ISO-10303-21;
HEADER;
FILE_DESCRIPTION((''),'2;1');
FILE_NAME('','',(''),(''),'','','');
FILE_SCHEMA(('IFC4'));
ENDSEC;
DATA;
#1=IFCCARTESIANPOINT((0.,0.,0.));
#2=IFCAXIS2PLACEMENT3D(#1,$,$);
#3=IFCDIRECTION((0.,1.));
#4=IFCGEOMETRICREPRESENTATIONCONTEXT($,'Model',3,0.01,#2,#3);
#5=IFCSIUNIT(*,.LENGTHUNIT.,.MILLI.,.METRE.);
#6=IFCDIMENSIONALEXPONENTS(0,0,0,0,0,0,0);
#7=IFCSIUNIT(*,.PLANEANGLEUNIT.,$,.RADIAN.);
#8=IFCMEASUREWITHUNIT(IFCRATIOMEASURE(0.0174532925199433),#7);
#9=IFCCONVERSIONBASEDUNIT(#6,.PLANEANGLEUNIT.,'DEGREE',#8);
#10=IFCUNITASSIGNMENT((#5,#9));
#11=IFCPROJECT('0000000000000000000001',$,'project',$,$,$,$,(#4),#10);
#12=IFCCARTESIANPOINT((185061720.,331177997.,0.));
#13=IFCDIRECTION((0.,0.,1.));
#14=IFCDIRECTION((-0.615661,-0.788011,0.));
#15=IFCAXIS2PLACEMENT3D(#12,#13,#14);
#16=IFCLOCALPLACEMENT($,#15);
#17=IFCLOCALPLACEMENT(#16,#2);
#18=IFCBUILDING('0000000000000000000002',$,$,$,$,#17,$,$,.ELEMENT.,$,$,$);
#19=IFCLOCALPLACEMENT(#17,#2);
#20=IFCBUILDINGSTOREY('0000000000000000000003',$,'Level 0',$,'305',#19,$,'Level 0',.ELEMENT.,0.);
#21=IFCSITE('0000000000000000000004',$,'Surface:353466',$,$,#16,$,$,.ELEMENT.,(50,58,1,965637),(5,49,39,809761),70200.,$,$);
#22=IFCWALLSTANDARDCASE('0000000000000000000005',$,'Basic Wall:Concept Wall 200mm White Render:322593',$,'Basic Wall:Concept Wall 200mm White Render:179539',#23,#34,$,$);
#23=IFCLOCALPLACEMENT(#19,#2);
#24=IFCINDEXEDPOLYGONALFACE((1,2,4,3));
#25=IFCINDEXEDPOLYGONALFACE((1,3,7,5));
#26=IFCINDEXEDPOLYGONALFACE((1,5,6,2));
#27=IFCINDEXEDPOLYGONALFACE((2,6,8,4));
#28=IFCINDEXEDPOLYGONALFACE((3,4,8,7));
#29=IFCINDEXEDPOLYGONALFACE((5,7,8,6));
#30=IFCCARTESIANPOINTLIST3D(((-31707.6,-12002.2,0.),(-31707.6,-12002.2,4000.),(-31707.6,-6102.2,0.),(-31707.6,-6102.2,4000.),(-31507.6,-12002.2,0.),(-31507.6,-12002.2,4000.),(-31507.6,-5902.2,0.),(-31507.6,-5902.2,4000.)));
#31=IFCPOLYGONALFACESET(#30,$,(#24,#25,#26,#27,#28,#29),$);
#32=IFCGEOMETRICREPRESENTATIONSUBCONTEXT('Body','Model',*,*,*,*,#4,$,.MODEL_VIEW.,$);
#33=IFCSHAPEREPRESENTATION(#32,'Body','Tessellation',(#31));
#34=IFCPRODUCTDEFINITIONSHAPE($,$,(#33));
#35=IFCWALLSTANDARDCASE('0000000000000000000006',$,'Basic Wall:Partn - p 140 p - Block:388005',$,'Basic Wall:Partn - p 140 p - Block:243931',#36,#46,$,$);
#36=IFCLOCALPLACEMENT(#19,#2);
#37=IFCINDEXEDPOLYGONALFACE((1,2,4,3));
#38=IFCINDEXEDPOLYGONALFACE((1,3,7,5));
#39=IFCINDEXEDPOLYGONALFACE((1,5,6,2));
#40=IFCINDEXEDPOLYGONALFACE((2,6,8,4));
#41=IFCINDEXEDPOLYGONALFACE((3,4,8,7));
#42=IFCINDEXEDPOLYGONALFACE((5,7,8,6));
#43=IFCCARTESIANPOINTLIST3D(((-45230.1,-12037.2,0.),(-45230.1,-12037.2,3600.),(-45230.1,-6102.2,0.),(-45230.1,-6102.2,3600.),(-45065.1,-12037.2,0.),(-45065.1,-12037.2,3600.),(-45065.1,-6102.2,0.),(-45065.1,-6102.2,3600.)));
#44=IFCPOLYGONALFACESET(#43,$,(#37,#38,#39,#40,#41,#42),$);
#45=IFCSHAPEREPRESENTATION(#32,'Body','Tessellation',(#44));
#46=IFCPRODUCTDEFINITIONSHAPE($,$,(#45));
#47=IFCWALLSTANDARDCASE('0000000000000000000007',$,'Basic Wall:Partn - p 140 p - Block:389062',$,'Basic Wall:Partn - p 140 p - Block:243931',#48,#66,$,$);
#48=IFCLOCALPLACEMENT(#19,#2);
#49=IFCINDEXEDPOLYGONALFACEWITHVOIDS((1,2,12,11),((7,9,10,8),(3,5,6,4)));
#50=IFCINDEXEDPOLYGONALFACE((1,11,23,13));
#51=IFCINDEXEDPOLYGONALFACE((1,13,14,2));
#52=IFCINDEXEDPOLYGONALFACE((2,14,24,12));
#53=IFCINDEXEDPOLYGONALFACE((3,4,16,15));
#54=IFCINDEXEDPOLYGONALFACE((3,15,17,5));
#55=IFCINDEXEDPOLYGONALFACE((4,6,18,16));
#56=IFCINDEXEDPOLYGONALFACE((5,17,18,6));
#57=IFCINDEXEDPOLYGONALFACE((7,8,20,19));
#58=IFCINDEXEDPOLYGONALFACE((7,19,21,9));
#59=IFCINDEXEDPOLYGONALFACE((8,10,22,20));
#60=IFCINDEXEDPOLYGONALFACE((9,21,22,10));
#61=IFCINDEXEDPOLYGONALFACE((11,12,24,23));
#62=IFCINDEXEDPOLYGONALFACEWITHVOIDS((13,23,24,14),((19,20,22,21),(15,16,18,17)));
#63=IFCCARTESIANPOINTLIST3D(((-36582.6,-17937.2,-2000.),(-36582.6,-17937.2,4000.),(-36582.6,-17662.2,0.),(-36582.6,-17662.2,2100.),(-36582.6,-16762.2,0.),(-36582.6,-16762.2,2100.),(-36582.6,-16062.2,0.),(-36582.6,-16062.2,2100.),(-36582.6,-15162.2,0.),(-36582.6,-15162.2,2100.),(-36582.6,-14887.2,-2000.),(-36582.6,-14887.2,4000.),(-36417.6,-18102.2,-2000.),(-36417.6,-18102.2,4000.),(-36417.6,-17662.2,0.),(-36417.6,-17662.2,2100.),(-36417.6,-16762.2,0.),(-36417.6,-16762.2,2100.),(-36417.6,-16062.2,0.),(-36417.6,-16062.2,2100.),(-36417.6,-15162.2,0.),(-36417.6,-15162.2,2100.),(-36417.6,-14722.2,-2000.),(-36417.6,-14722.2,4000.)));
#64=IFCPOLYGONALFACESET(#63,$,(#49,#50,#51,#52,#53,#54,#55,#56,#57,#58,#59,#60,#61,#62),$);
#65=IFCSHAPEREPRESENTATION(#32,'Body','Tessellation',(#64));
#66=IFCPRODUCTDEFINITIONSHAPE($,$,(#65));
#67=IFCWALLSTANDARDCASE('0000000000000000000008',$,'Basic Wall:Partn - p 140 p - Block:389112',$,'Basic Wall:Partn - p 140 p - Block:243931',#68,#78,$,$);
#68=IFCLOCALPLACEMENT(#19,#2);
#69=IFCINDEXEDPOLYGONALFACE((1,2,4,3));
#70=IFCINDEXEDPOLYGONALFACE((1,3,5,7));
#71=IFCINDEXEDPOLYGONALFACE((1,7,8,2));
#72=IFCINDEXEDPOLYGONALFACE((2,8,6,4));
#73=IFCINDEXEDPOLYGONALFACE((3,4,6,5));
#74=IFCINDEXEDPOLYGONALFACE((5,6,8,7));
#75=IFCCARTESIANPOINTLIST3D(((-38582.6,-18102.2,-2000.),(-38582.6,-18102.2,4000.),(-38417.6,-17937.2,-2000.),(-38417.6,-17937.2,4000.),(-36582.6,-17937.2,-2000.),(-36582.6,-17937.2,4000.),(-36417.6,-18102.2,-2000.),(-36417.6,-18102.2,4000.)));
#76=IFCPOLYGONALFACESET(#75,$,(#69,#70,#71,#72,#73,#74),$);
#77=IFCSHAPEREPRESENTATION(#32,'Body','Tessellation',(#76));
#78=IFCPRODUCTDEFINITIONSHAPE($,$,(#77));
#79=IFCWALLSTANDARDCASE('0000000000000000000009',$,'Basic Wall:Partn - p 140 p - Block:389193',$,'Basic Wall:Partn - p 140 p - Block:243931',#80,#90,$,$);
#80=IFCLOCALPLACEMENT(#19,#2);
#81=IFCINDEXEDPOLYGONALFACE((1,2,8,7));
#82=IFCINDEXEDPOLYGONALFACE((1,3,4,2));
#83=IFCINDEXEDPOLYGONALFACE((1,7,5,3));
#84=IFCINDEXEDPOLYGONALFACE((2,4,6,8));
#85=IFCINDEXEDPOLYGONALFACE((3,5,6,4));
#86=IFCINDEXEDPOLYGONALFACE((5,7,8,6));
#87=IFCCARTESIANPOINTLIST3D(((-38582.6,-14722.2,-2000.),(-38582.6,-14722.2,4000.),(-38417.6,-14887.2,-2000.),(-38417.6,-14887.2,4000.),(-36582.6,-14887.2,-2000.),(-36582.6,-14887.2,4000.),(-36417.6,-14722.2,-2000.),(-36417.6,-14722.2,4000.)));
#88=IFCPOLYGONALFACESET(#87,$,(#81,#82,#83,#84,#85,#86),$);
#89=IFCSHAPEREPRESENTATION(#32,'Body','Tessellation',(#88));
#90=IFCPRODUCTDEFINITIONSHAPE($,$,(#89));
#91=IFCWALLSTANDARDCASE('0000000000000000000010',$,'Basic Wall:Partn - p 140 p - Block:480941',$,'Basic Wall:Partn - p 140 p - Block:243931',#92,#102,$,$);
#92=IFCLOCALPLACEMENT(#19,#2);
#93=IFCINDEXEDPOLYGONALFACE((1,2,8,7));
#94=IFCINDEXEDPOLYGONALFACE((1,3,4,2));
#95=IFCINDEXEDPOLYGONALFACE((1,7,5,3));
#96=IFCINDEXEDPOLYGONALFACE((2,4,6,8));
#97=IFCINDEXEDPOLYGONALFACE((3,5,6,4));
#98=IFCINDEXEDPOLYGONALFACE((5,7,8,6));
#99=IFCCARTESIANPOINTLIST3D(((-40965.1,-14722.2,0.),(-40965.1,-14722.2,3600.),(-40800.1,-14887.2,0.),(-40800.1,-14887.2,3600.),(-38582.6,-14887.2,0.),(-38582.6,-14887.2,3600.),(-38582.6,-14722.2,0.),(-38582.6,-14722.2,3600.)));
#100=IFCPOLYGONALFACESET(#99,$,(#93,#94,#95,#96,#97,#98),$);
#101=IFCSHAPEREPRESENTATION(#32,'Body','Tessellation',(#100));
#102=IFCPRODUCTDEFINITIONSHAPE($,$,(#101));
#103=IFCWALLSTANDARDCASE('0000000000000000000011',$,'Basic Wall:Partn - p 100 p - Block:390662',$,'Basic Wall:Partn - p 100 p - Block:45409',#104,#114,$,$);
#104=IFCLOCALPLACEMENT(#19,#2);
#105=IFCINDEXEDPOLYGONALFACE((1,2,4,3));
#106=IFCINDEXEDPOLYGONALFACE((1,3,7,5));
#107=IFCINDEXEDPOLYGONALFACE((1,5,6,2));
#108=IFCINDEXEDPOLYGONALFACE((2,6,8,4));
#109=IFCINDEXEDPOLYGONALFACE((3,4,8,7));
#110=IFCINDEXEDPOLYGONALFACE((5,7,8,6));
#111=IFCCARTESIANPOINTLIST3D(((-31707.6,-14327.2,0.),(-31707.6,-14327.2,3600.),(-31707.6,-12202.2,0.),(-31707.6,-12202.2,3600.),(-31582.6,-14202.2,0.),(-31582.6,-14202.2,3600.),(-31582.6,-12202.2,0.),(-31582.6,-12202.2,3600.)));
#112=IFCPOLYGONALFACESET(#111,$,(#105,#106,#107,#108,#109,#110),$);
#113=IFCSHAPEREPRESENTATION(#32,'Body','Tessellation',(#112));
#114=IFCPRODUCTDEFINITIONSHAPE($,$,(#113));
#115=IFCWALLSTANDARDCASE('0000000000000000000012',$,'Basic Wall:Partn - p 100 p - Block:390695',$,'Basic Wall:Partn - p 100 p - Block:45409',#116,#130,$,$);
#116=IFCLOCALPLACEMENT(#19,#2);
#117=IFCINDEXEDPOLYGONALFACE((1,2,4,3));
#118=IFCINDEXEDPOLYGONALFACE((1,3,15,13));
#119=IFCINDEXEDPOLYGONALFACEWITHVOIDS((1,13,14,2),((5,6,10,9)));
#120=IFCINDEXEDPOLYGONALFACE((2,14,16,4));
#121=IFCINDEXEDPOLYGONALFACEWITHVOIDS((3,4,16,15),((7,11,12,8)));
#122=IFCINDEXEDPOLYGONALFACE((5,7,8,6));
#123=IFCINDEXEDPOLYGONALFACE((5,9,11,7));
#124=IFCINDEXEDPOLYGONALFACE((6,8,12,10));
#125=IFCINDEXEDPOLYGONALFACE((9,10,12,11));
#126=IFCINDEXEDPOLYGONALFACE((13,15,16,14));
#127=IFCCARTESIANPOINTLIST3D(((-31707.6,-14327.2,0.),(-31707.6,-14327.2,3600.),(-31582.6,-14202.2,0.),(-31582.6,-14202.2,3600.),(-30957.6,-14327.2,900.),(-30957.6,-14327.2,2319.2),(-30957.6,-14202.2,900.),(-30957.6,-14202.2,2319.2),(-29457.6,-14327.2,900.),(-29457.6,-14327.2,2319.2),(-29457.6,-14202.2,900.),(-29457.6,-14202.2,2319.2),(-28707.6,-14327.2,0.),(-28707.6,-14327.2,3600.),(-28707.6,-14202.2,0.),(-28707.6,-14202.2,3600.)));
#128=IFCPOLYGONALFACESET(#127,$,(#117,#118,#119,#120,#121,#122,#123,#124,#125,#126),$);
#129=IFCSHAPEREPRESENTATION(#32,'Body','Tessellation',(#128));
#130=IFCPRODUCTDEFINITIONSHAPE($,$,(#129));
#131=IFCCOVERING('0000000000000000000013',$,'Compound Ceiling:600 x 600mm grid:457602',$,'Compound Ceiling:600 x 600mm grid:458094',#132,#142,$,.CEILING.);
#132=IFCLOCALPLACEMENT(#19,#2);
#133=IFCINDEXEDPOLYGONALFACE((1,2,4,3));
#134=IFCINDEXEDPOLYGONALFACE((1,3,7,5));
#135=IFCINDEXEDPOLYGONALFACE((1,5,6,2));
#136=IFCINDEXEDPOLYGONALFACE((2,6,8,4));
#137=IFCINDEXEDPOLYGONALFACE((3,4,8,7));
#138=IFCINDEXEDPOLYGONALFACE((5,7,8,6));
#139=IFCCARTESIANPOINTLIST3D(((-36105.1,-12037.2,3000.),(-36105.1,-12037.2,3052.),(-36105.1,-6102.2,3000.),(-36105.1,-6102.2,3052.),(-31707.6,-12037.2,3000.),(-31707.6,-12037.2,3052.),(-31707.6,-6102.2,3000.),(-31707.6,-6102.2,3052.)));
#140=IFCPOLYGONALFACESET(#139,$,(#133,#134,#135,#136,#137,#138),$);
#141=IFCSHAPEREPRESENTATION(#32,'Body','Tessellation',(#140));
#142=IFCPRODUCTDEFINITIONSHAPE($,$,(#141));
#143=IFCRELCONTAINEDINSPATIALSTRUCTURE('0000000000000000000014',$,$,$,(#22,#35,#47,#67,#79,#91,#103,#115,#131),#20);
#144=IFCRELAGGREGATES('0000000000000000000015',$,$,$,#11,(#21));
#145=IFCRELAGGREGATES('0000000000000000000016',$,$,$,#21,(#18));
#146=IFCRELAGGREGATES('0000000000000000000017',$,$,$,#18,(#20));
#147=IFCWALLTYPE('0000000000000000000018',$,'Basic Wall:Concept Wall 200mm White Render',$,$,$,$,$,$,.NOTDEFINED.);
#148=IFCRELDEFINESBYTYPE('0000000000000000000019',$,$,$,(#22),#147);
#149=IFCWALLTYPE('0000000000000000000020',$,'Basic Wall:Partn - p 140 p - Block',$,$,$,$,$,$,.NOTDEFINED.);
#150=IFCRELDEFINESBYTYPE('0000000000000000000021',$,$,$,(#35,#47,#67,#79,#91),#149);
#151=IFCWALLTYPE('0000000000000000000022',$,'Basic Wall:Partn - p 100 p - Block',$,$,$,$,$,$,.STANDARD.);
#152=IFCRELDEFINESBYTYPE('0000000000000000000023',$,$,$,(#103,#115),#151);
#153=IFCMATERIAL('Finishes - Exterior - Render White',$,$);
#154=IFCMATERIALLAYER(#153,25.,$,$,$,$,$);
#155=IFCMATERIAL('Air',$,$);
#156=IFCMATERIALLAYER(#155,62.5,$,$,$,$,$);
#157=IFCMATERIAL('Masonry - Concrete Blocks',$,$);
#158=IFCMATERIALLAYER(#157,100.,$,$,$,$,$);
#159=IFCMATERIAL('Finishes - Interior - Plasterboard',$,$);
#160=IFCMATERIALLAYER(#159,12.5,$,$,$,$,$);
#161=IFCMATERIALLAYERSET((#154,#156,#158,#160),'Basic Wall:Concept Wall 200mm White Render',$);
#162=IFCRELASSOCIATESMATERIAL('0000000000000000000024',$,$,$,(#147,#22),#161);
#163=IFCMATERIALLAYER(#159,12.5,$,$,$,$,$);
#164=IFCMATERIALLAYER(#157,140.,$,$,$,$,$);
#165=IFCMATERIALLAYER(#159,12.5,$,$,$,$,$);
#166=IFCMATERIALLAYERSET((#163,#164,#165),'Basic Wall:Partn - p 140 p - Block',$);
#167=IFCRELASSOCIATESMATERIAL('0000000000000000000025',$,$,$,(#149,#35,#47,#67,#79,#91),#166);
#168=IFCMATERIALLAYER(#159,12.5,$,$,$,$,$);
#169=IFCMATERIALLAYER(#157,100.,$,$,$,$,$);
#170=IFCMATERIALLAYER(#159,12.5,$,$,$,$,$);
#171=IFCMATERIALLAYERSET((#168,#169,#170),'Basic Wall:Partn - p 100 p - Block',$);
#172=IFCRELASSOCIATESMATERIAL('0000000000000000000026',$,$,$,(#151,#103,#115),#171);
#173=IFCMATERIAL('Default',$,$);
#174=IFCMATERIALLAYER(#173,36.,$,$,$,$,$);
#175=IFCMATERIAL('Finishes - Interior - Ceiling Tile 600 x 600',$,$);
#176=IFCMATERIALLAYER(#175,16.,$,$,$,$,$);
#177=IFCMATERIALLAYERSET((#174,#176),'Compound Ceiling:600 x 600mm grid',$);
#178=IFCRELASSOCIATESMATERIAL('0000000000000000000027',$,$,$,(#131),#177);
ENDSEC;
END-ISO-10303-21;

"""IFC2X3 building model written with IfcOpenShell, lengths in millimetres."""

from ifc_helpers import new_model, entity, si_unit, converted_unit, direction, frame, frame_2d, origin, place, context, subcontext, project, spatial, polyline, rectangle, outline, extrude, clip, halfspace, bounded_halfspace, material, layer, layer_set, layer_usage, type_object, element, save


model = new_model("IFC2X3")

# Units and contexts
model_context = context("Model", 3, precision=0.01, world=origin(), true_north=direction((0.0, 1.0)))
body_context = subcontext(model_context, "Body", "Model", "MODEL_VIEW")
ifc_project = project(units=[si_unit("LENGTHUNIT", "METRE", prefix="MILLI"), converted_unit("PLANEANGLEUNIT", "DEGREE", entity("IfcRatioMeasure", 0.0174532925199433), si_unit("PLANEANGLEUNIT", "RADIAN"), dimensions=[0, 0, 0, 0, 0, 0, 0])], contexts=[model_context])

# Site, building, storey
site_placement = place(None, frame((185061720.0, 331177997.0, 0.0), z_axis=(0.0, 0.0, 1.0), x_axis=(-0.615661, -0.788011, 0.0)))
site = spatial("IfcSite", under=ifc_project, at=site_placement, Name="Surface:353466", CompositionType="ELEMENT", RefLatitude=(50, 58, 1, 965637), RefLongitude=(5, 49, 39, 809761), RefElevation=70200.0)
building_placement = place(site_placement, origin())
building = spatial("IfcBuilding", under=site, at=building_placement, CompositionType="ELEMENT")
storey_placement = place(building_placement, origin())
storey = spatial("IfcBuildingStorey", under=building, at=storey_placement, Name="Level 0", ObjectType="305", LongName="Level 0", CompositionType="ELEMENT", Elevation=0.0)

# Walls
ifc_material_1 = material(Name="Finishes - Exterior - Render White")
ifc_layer_1 = layer(ifc_material_1, 25.0)
ifc_material_2 = material(Name="Air")
ifc_layer_2 = layer(ifc_material_2, 62.5)
ifc_material_3 = material(Name="Masonry - Concrete Blocks")
ifc_layer_3 = layer(ifc_material_3, 100.0)
ifc_material_4 = material(Name="Finishes - Interior - Plasterboard")
ifc_layer_4 = layer(ifc_material_4, 12.5)
ifc_layer_set_1 = layer_set([ifc_layer_1, ifc_layer_2, ifc_layer_3, ifc_layer_4], Name="Basic Wall:Concept Wall 200mm White Render")
ifc_layer_usage_1 = layer_usage(ifc_layer_set_1, "AXIS2", "POSITIVE", -100.0)
wall_type_1 = type_object("IfcWallType", Name="Basic Wall:Concept Wall 200mm White Render", PredefinedType="NOTDEFINED", material=ifc_layer_set_1)
wall_1_placement = place(storey_placement, frame((-31607.6, -12002.2, 0.0), z_axis=(0.0, 0.0, 1.0), x_axis=(0.0, 1.0, 0.0)))
element("IfcWallStandardCase", 1, at=wall_1_placement, inside=storey, type_object=wall_type_1, material=ifc_layer_usage_1, Name="Basic Wall:Concept Wall 200mm White Render:322593", ObjectType="Basic Wall:Concept Wall 200mm White Render:179539", context=body_context, shape_type="Clipping", body=[
    clip(extrude(outline(polyline([(6100.0, -100.0), (5900.0, 100.0), (0.0, 100.0), (0.0, -100.0), (6100.0, -100.0)])), origin(), (0.0, 0.0, 1.0), 4000.0), halfspace(origin(), True)),
])
ifc_layer_5 = layer(ifc_material_4, 12.5)
ifc_layer_6 = layer(ifc_material_3, 140.0)
ifc_layer_7 = layer(ifc_material_4, 12.5)
ifc_layer_set_2 = layer_set([ifc_layer_5, ifc_layer_6, ifc_layer_7], Name="Basic Wall:Partn - p 140 p - Block")
ifc_layer_usage_2 = layer_usage(ifc_layer_set_2, "AXIS2", "NEGATIVE", 82.5)
wall_type_2 = type_object("IfcWallType", Name="Basic Wall:Partn - p 140 p - Block", PredefinedType="NOTDEFINED", material=ifc_layer_set_2)
wall_2_placement = place(storey_placement, frame((-45147.6, -6102.2, 0.0), z_axis=(0.0, 0.0, 1.0), x_axis=(0.0, -1.0, 0.0)))
element("IfcWallStandardCase", 2, at=wall_2_placement, inside=storey, type_object=wall_type_2, material=ifc_layer_usage_2, Name="Basic Wall:Partn - p 140 p - Block:388005", ObjectType="Basic Wall:Partn - p 140 p - Block:243931", context=body_context, shape_type="Clipping", body=[
    clip(extrude(rectangle(XDim=5935.0, YDim=165.0, at=frame_2d((2967.5, 0.0), x_axis=(-1.0, 0.0))), origin(), (0.0, 0.0, 1.0), 3600.0), bounded_halfspace(frame((0.0, -82.5, 3600.0), z_axis=(0.0, 0.0, -1.0), x_axis=(0.0, 1.0, 0.0)), True, frame((0.0, -82.5, 3600.0)), polyline([(0.0, 0.0), (5935.0, 0.0), (5935.0, 165.0), (0.0, 165.0), (0.0, 0.0)]))),
])

# Wall, openings
ifc_layer_usage_3 = layer_usage(ifc_layer_set_2, "AXIS2", "NEGATIVE", 82.5)
wall_3_placement = place(storey_placement, frame((-36500.1, -14722.2, -2000.0), z_axis=(0.0, 0.0, 1.0), x_axis=(0.0, -1.0, 0.0)))
wall_3 = element("IfcWallStandardCase", 3, at=wall_3_placement, inside=storey, type_object=wall_type_2, material=ifc_layer_usage_3, Name="Basic Wall:Partn - p 140 p - Block:389062", ObjectType="Basic Wall:Partn - p 140 p - Block:243931", context=body_context, shape_type="Clipping", body=[
    clip(extrude(outline(polyline([(3215.0, -82.5), (3380.0, 82.5), (0.0, 82.5), (165.0, -82.5), (3215.0, -82.5)])), origin(), (0.0, 0.0, 1.0), 6000.0), halfspace(frame((0.0, 0.0, -2000.0)), True)),
])
opening_1_placement = place(wall_3_placement, frame((1340.0, -1606.5, 2000.0)))
element("IfcOpeningElement", 4, at=opening_1_placement, cuts=wall_3, ObjectType="Opening", context=body_context, shape_type="SweptSolid", body=[
    extrude(rectangle(XDim=2100.0, YDim=900.0, at=frame_2d((0.0, 0.0), x_axis=(0.0, 1.0))), frame((-450.0, 0.0, 1050.0), z_axis=(0.0, 1.0, 0.0), x_axis=(-1.0, 0.0, 0.0)), (0.0, 0.0, 1.0), 3048.0),
])
opening_2_placement = place(wall_3_placement, frame((2940.0, -1606.5, 2000.0)))
element("IfcOpeningElement", 5, at=opening_2_placement, cuts=wall_3, ObjectType="Opening", context=body_context, shape_type="SweptSolid", body=[
    extrude(rectangle(XDim=2100.0, YDim=900.0, at=frame_2d((0.0, 0.0), x_axis=(0.0, 1.0))), frame((-450.0, 0.0, 1050.0), z_axis=(0.0, 1.0, 0.0), x_axis=(-1.0, 0.0, 0.0)), (0.0, 0.0, 1.0), 3048.0),
])
opening_3_placement = place(wall_3_placement, frame((1340.0, -1606.5, 6000.0)))
element("IfcOpeningElement", 6, at=opening_3_placement, cuts=wall_3, ObjectType="Opening", context=body_context, shape_type="SweptSolid", body=[
    extrude(rectangle(XDim=2100.0, YDim=900.0, at=frame_2d((0.0, 0.0), x_axis=(0.0, 1.0))), frame((-450.0, 0.0, 1050.0), z_axis=(0.0, 1.0, 0.0), x_axis=(-1.0, 0.0, 0.0)), (0.0, 0.0, 1.0), 3048.0),
])
opening_4_placement = place(wall_3_placement, frame((2940.0, -1606.5, 6000.0)))
element("IfcOpeningElement", 7, at=opening_4_placement, cuts=wall_3, ObjectType="Opening", context=body_context, shape_type="SweptSolid", body=[
    extrude(rectangle(XDim=2100.0, YDim=900.0, at=frame_2d((0.0, 0.0), x_axis=(0.0, 1.0))), frame((-450.0, 0.0, 1050.0), z_axis=(0.0, 1.0, 0.0), x_axis=(-1.0, 0.0, 0.0)), (0.0, 0.0, 1.0), 3048.0),
])

# Walls
ifc_layer_usage_4 = layer_usage(ifc_layer_set_2, "AXIS2", "NEGATIVE", 82.5)
wall_4_placement = place(storey_placement, frame((-36417.6, -18019.7, -2000.0), z_axis=(0.0, 0.0, 1.0), x_axis=(-1.0, 0.0, 0.0)))
element("IfcWallStandardCase", 8, at=wall_4_placement, inside=storey, type_object=wall_type_2, material=ifc_layer_usage_4, Name="Basic Wall:Partn - p 140 p - Block:389112", ObjectType="Basic Wall:Partn - p 140 p - Block:243931", context=body_context, shape_type="Clipping", body=[
    clip(extrude(outline(polyline([(2000.0, -82.5), (2165.0, 82.5), (0.0, 82.5), (165.0, -82.5), (2000.0, -82.5)])), origin(), (0.0, 0.0, 1.0), 6000.0), halfspace(frame((0.0, 0.0, -2000.0)), True)),
])
ifc_layer_usage_5 = layer_usage(ifc_layer_set_2, "AXIS2", "NEGATIVE", 82.5)
wall_5_placement = place(storey_placement, frame((-38582.6, -14804.7, -2000.0)))
element("IfcWallStandardCase", 9, at=wall_5_placement, inside=storey, type_object=wall_type_2, material=ifc_layer_usage_5, Name="Basic Wall:Partn - p 140 p - Block:389193", ObjectType="Basic Wall:Partn - p 140 p - Block:243931", context=body_context, shape_type="Clipping", body=[
    clip(extrude(outline(polyline([(2000.0, -82.5), (2165.0, 82.5), (0.0, 82.5), (165.0, -82.5), (2000.0, -82.5)])), origin(), (0.0, 0.0, 1.0), 6000.0), halfspace(frame((0.0, 0.0, -2000.0)), True)),
])
ifc_layer_usage_6 = layer_usage(ifc_layer_set_2, "AXIS2", "NEGATIVE", 82.5)
wall_6_placement = place(storey_placement, frame((-38582.6, -14804.7, 0.0), z_axis=(0.0, 0.0, 1.0), x_axis=(-1.0, 0.0, 0.0)))
element("IfcWallStandardCase", 10, at=wall_6_placement, inside=storey, type_object=wall_type_2, material=ifc_layer_usage_6, Name="Basic Wall:Partn - p 140 p - Block:480941", ObjectType="Basic Wall:Partn - p 140 p - Block:243931", context=body_context, shape_type="Clipping", body=[
    clip(extrude(outline(polyline([(2382.5, -82.5), (2217.5, 82.5), (0.0, 82.5), (0.0, -82.5), (2382.5, -82.5)])), origin(), (0.0, 0.0, 1.0), 3600.0), bounded_halfspace(frame((0.0, -82.5, 3600.0), z_axis=(0.0, 0.0, -1.0), x_axis=(-1.0, 0.0, 0.0)), True, frame((0.0, -82.5, 3600.0)), polyline([(0.0, 0.0), (2382.5, 0.0), (2217.5, 165.0), (0.0, 165.0), (0.0, 0.0)]))),
])

# Wall
ifc_layer_8 = layer(ifc_material_4, 12.5)
ifc_layer_9 = layer(ifc_material_3, 100.0)
ifc_layer_10 = layer(ifc_material_4, 12.5)
ifc_layer_set_3 = layer_set([ifc_layer_8, ifc_layer_9, ifc_layer_10], Name="Basic Wall:Partn - p 100 p - Block")
ifc_layer_usage_7 = layer_usage(ifc_layer_set_3, "AXIS2", "NEGATIVE", 62.5)
wall_type_3 = type_object("IfcWallType", Name="Basic Wall:Partn - p 100 p - Block", PredefinedType="STANDARD", material=ifc_layer_set_3)
wall_7_placement = place(storey_placement, frame((-31645.1, -12202.2, 0.0), z_axis=(0.0, 0.0, 1.0), x_axis=(0.0, -1.0, 0.0)))
element("IfcWallStandardCase", 11, at=wall_7_placement, inside=storey, type_object=wall_type_3, material=ifc_layer_usage_7, Name="Basic Wall:Partn - p 100 p - Block:390662", ObjectType="Basic Wall:Partn - p 100 p - Block:45409", context=body_context, shape_type="Clipping", body=[
    clip(extrude(outline(polyline([(2125.0, -62.5), (2000.0, 62.5), (0.0, 62.5), (0.0, -62.5), (2125.0, -62.5)])), origin(), (0.0, 0.0, 1.0), 3600.0), bounded_halfspace(frame((0.0, -62.5, 3600.0), z_axis=(0.0, 0.0, -1.0), x_axis=(0.0, 1.0, 0.0)), True, frame((0.0, -62.5, 3600.0)), polyline([(0.0, 0.0), (2125.0, 0.0), (2000.0, 125.0), (0.0, 125.0), (0.0, 0.0)]))),
])

# Wall, opening
ifc_layer_usage_8 = layer_usage(ifc_layer_set_3, "AXIS2", "NEGATIVE", 62.5)
wall_8_placement = place(storey_placement, frame((-31707.6, -14264.7, 0.0)))
wall_8 = element("IfcWallStandardCase", 12, at=wall_8_placement, inside=storey, type_object=wall_type_3, material=ifc_layer_usage_8, Name="Basic Wall:Partn - p 100 p - Block:390695", ObjectType="Basic Wall:Partn - p 100 p - Block:45409", context=body_context, shape_type="Clipping", body=[
    clip(extrude(outline(polyline([(3000.0, -62.5), (3000.0, 62.5), (125.0, 62.5), (0.0, -62.5), (3000.0, -62.5)])), origin(), (0.0, 0.0, 1.0), 3600.0), bounded_halfspace(frame((0.0, -62.5, 3600.0), z_axis=(0.0, 0.0, -1.0), x_axis=(1.0, 0.0, 0.0)), True, frame((0.0, -62.5, 3600.0)), polyline([(0.0, 0.0), (3000.0, 0.0), (3000.0, 125.0), (125.0, 125.0), (0.0, 0.0)]))),
])
opening_5_placement = place(wall_8_placement, frame((750.0, -62.5, 900.0)))
element("IfcOpeningElement", 13, at=opening_5_placement, cuts=wall_8, ObjectType="Opening", context=body_context, shape_type="SweptSolid", body=[
    extrude(rectangle(XDim=1419.2, YDim=1500.0, at=frame_2d((0.0, 0.0), x_axis=(1.0, 0.0))), frame((750.0, 0.0, 709.6), z_axis=(0.0, 1.0, 0.0), x_axis=(0.0, 0.0, -1.0)), (0.0, 0.0, 1.0), 125.0),
])

# Covering
ifc_material_5 = material(Name="Default")
ifc_layer_11 = layer(ifc_material_5, 36.0)
ifc_material_6 = material(Name="Finishes - Interior - Ceiling Tile 600 x 600")
ifc_layer_12 = layer(ifc_material_6, 16.0)
ifc_layer_set_4 = layer_set([ifc_layer_11, ifc_layer_12], Name="Compound Ceiling:600 x 600mm grid")
ifc_layer_usage_9 = layer_usage(ifc_layer_set_4, "AXIS3", "POSITIVE", 0.0)
covering_1_placement = place(storey_placement, frame((-36105.1, -12037.2, 3000.0)))
element("IfcCovering", 14, at=covering_1_placement, inside=storey, material=ifc_layer_usage_9, Name="Compound Ceiling:600 x 600mm grid:457602", ObjectType="Compound Ceiling:600 x 600mm grid:458094", PredefinedType="CEILING", context=body_context, shape_type="SweptSolid", body=[
    extrude(rectangle(XDim=5935.0, YDim=4397.5, at=frame_2d((0.0, 0.0), x_axis=(1.0, 0.0))), frame((2198.7, 2967.5, 0.0), z_axis=(0.0, 0.0, 1.0), x_axis=(0.0, -1.0, 0.0)), (0.0, 0.0, 1.0), 52.0),
])

save(model, "model.ifc")
